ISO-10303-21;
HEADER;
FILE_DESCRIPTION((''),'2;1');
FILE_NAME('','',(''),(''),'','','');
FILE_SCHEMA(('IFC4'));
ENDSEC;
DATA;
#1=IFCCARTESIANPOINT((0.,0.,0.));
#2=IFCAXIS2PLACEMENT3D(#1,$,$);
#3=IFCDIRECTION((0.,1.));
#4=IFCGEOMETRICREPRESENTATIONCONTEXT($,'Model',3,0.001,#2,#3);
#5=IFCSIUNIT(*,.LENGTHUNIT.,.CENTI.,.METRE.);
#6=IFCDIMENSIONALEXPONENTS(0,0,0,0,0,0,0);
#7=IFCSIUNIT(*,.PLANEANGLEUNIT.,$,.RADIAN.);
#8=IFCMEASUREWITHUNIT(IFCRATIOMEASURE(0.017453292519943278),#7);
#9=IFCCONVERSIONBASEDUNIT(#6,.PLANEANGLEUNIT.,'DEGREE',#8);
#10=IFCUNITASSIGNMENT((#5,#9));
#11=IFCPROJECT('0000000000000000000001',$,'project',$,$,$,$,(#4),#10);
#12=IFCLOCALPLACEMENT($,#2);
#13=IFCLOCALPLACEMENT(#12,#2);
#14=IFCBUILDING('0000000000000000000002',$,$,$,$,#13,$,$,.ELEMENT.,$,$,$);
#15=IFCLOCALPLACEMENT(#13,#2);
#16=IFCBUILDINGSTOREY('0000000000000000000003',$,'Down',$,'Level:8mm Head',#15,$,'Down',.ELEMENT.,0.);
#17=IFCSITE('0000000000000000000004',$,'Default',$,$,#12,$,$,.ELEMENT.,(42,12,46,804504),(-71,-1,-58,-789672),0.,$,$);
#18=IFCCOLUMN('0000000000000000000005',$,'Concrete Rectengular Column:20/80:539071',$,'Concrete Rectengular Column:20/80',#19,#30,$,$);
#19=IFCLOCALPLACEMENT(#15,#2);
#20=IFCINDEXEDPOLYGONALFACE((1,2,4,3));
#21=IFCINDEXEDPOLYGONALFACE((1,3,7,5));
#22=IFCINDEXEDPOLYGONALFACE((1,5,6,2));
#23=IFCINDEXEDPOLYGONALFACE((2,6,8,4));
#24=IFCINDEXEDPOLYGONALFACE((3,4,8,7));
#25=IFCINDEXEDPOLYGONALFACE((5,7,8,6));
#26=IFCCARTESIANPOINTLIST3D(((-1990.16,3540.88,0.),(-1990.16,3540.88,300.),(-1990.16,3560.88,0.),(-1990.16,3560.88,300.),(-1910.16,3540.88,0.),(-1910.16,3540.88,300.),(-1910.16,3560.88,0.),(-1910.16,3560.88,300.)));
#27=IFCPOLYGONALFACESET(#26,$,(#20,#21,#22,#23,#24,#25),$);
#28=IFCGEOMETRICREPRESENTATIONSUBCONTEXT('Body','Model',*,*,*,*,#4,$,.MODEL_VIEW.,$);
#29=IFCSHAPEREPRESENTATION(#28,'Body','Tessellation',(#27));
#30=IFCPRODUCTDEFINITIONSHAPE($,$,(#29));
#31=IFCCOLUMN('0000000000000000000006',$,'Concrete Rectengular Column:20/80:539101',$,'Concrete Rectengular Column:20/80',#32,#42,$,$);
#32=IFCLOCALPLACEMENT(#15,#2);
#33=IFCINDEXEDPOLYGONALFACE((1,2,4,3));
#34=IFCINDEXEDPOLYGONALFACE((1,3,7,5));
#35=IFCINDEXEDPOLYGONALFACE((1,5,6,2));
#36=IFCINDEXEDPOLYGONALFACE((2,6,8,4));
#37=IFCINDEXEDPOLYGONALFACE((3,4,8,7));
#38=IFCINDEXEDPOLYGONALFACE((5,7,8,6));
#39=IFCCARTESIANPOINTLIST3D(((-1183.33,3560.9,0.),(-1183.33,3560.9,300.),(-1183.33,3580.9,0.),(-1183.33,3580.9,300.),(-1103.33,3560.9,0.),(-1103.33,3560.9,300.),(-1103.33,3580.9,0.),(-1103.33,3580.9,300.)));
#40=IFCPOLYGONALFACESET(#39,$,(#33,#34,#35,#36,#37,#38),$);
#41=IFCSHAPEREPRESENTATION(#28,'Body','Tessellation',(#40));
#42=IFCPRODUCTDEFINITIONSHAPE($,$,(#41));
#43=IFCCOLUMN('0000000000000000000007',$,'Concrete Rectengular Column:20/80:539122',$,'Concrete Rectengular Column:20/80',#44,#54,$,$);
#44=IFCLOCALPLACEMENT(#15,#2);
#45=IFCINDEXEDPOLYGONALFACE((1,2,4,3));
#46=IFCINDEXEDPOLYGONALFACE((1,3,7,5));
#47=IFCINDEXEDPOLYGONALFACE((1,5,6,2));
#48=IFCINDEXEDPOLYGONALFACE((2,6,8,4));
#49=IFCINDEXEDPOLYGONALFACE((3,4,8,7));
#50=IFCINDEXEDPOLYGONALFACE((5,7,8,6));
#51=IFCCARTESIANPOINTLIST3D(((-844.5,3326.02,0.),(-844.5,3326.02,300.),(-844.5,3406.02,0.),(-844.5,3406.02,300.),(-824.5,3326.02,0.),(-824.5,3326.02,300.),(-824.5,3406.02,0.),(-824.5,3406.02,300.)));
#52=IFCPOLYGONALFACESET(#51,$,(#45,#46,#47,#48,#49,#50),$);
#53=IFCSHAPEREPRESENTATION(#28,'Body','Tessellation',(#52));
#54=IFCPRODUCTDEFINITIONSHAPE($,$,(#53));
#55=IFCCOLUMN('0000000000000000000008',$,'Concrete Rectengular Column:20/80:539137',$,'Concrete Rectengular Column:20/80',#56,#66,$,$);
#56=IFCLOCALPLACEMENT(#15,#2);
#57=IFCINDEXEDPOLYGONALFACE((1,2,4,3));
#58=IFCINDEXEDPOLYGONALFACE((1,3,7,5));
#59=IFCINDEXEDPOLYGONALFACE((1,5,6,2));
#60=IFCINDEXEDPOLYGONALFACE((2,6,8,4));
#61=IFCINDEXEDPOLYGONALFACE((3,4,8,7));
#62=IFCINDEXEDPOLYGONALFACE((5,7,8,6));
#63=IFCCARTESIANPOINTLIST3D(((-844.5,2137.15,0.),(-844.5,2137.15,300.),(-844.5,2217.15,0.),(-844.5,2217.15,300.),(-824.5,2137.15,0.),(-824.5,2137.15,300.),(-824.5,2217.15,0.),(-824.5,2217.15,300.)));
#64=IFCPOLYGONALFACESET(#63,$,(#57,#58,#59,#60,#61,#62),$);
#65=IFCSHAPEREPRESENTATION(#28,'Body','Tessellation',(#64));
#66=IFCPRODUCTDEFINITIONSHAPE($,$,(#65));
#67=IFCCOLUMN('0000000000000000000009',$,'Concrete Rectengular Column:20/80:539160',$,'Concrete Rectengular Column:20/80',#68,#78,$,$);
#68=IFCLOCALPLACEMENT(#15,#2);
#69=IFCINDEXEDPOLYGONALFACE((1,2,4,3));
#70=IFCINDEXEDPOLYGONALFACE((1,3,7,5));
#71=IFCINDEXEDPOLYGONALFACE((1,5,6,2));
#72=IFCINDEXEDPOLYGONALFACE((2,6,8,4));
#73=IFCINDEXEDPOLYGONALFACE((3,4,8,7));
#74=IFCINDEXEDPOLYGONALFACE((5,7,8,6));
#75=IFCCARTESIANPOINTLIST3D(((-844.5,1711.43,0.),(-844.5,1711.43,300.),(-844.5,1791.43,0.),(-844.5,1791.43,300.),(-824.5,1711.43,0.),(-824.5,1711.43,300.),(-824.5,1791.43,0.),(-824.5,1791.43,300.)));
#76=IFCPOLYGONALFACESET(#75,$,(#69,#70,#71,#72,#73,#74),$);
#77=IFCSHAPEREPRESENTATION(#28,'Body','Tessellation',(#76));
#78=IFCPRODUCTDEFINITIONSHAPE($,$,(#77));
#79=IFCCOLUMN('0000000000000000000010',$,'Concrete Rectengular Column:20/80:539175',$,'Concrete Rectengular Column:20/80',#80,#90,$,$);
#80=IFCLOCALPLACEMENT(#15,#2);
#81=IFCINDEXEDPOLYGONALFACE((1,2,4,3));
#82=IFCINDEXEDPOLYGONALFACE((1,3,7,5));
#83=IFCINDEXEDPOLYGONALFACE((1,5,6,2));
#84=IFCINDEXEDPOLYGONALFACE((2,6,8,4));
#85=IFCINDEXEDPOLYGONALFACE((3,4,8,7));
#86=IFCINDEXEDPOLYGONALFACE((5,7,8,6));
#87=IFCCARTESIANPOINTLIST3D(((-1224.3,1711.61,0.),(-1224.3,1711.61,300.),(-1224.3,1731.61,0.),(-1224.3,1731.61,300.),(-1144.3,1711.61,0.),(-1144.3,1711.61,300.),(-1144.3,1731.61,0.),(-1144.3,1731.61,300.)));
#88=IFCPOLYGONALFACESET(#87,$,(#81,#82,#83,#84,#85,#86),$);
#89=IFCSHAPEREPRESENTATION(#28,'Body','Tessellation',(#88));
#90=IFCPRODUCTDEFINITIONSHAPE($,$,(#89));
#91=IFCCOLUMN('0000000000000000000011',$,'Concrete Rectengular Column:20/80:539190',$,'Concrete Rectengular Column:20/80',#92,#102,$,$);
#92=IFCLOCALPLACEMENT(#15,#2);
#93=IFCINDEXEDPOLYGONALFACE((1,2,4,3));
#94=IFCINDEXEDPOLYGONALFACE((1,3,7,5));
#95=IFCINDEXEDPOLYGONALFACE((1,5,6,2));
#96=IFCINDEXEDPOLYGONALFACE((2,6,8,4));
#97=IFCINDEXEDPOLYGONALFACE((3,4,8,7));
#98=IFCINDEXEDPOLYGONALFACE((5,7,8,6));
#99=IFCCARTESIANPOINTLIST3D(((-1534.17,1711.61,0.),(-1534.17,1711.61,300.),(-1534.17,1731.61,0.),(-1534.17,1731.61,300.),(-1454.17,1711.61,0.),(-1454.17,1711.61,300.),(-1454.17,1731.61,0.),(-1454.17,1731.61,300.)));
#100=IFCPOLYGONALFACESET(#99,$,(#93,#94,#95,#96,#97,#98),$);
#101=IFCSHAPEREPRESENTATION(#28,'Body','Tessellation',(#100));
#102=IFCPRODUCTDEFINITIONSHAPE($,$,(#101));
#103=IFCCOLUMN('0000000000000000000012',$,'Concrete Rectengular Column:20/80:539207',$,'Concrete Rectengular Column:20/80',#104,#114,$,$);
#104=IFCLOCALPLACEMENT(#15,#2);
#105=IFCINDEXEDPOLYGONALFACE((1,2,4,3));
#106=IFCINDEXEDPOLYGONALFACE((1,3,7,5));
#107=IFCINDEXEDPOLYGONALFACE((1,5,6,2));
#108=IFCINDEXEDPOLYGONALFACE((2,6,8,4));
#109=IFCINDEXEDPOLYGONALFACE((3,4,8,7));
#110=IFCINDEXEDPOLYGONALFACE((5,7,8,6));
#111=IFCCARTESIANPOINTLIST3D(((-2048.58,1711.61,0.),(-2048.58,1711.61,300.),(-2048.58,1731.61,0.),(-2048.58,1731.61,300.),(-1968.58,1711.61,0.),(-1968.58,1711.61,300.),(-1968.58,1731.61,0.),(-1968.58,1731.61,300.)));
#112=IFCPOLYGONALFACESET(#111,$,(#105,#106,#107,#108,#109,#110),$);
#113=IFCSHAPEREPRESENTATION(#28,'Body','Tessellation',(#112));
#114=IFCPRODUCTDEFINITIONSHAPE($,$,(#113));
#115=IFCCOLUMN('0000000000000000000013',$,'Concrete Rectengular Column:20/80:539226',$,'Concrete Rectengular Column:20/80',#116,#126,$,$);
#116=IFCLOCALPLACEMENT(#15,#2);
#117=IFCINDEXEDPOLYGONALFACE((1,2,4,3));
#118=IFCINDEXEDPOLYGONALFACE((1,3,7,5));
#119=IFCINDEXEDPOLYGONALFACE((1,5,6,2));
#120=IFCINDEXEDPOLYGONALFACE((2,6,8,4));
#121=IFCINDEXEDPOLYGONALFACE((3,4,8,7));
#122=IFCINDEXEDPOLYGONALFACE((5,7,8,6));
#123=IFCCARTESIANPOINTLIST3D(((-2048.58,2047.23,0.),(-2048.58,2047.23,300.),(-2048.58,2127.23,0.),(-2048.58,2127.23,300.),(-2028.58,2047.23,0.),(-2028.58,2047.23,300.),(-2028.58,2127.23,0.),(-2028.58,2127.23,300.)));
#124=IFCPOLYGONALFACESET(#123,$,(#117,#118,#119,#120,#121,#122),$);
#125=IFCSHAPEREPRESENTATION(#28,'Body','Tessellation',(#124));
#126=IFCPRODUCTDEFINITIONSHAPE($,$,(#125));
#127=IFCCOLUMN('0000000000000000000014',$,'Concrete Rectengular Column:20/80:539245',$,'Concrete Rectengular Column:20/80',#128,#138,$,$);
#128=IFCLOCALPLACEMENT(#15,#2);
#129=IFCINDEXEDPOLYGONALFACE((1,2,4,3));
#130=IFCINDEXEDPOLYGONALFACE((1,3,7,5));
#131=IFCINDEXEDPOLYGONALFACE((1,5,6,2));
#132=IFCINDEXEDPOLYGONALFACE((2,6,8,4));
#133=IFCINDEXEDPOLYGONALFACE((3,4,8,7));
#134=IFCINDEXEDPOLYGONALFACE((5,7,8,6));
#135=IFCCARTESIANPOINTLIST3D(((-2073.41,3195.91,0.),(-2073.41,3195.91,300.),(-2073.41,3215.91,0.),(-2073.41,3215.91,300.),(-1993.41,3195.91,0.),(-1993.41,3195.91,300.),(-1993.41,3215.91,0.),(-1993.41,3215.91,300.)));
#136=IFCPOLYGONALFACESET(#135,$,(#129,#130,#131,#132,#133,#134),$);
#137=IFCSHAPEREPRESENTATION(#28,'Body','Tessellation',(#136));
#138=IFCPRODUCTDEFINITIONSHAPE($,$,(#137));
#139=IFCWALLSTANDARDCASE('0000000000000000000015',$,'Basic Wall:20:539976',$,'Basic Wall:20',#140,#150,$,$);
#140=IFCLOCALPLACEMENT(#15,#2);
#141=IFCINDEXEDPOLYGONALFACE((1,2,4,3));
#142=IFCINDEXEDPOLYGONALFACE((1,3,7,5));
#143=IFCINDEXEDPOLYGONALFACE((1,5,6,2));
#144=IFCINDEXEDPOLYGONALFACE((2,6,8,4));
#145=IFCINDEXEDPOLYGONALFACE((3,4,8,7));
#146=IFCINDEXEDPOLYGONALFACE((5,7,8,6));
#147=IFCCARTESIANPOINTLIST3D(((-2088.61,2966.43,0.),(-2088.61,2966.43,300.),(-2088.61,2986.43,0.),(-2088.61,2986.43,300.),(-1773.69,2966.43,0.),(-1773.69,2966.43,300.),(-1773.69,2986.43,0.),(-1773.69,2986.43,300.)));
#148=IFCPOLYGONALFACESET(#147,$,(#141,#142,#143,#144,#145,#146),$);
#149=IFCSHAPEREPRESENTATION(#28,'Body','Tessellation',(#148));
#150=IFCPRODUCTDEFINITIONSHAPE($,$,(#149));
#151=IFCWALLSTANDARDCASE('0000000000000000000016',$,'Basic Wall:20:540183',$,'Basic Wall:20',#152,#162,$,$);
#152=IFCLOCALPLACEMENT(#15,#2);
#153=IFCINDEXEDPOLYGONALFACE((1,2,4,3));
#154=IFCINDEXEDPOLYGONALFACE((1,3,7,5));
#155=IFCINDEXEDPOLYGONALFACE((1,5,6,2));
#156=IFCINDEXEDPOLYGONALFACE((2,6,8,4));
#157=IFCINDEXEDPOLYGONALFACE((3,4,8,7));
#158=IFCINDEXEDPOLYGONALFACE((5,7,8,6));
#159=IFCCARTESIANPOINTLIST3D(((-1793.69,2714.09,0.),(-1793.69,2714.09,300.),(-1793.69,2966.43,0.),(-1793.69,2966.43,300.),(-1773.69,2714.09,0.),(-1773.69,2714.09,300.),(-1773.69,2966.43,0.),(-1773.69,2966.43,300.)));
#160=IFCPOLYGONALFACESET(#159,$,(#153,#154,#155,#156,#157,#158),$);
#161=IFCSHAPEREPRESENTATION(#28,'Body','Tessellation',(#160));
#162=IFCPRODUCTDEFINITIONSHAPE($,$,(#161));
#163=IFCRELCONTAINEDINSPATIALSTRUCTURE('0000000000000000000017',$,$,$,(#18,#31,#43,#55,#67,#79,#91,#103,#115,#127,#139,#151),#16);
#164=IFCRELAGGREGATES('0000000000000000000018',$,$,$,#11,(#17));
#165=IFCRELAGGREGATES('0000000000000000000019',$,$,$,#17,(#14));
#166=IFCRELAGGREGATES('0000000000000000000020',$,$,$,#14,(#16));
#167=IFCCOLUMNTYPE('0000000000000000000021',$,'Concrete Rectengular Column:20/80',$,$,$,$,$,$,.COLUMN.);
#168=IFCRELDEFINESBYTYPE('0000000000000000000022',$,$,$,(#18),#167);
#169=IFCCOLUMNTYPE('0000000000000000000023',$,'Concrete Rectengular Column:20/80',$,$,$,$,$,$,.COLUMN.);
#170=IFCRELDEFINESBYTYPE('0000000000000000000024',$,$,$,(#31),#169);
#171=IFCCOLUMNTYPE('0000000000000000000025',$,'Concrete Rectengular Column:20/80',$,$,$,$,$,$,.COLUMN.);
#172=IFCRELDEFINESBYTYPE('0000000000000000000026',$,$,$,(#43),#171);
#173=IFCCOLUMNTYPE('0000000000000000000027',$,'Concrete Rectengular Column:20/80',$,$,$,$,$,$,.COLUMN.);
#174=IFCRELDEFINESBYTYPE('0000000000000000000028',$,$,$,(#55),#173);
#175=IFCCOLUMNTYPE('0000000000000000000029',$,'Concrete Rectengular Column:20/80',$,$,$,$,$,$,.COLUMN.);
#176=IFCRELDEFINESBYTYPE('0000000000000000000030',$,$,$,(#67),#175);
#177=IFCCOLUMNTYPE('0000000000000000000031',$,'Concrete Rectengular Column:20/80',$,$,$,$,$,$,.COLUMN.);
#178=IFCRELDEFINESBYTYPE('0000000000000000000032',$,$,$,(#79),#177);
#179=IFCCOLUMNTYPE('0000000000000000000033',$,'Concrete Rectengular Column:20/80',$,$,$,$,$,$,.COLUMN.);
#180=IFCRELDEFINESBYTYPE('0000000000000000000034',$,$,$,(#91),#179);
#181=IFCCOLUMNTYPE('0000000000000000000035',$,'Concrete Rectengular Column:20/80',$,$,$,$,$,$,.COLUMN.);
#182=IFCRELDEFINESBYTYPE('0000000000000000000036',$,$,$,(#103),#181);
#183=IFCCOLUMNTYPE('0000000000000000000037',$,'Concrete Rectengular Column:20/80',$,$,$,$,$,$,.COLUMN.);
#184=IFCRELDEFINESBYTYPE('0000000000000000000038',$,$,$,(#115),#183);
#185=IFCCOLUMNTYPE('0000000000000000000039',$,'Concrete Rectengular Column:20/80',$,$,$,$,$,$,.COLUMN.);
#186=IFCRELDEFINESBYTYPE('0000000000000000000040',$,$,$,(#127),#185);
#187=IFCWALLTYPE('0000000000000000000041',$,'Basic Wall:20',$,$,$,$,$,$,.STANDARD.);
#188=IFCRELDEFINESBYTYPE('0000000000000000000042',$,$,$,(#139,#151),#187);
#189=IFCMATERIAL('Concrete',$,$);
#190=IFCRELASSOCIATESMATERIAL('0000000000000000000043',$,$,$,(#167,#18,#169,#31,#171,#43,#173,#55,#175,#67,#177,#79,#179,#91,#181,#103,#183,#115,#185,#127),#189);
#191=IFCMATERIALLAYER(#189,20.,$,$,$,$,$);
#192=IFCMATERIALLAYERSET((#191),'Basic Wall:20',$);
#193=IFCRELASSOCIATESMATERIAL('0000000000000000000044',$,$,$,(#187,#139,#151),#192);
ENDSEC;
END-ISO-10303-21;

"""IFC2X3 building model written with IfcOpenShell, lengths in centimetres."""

from ifc_helpers import new_model, entity, si_unit, converted_unit, direction, frame, frame_2d, origin, origin_2d_with_axis, place, context, subcontext, project, spatial, rectangle, extrude, source, transform, mapped, material, layer, layer_set, layer_usage, type_object, type_shapes, element, save


model = new_model("IFC2X3")

# Units and contexts
model_context = context("Model", 3, precision=0.001, world=origin(), true_north=direction((0.0, 1.0)))
body_context = subcontext(model_context, "Body", "Model", "MODEL_VIEW")
ifc_project = project(units=[si_unit("LENGTHUNIT", "METRE", prefix="CENTI"), converted_unit("PLANEANGLEUNIT", "DEGREE", entity("IfcRatioMeasure", 0.017453292519943278), si_unit("PLANEANGLEUNIT", "RADIAN"), dimensions=[0, 0, 0, 0, 0, 0, 0])], contexts=[model_context])

# Site, building, storey
site_placement = place(None, origin())
site = spatial("IfcSite", under=ifc_project, at=site_placement, Name="Default", CompositionType="ELEMENT", RefLatitude=(42, 12, 46, 804504), RefLongitude=(-71, -1, -58, -789672), RefElevation=0.0)
building_placement = place(site_placement, origin())
building = spatial("IfcBuilding", under=site, at=building_placement, CompositionType="ELEMENT")
storey_placement = place(building_placement, origin())
storey = spatial("IfcBuildingStorey", under=building, at=storey_placement, Name="Down", ObjectType="Level:8mm Head", LongName="Down", CompositionType="ELEMENT", Elevation=0.0)

# Columns
ifc_material = material(Name="Concrete")
column_type_1 = type_object("IfcColumnType", Name="Concrete Rectengular Column:20/80", PredefinedType="COLUMN", material=ifc_material)
shared_shape_1 = source(origin(), body_context, "Body", "SweptSolid", [
    extrude(rectangle(XDim=20.0, YDim=80.0, at=origin_2d_with_axis()), frame((-1950.16, 3550.88, 0.0), z_axis=(0.0, 0.0, 1.0), x_axis=(0.0, -1.0, 0.0)), (0.0, 0.0, 1.0), 300.0),
])
type_shapes(column_type_1, [shared_shape_1])
column_1_placement = place(storey_placement, origin())
element("IfcColumn", 1, at=column_1_placement, inside=storey, type_object=column_type_1, material=ifc_material, Name="Concrete Rectengular Column:20/80:539071", ObjectType="Concrete Rectengular Column:20/80", context=body_context, shape_type="MappedRepresentation", body=[
    mapped(shared_shape_1, transform((0.0, 0.0, 0.0), scale=1.0)),
])
column_type_2 = type_object("IfcColumnType", Name="Concrete Rectengular Column:20/80", PredefinedType="COLUMN", material=ifc_material)
shared_shape_2 = source(origin(), body_context, "Body", "SweptSolid", [
    extrude(rectangle(XDim=20.0, YDim=80.0, at=origin_2d_with_axis()), frame((-1143.33, 3570.9, 0.0), z_axis=(0.0, 0.0, 1.0), x_axis=(0.0, -1.0, 0.0)), (0.0, 0.0, 1.0), 300.0),
])
type_shapes(column_type_2, [shared_shape_2])
column_2_placement = place(storey_placement, origin())
element("IfcColumn", 2, at=column_2_placement, inside=storey, type_object=column_type_2, material=ifc_material, Name="Concrete Rectengular Column:20/80:539101", ObjectType="Concrete Rectengular Column:20/80", context=body_context, shape_type="MappedRepresentation", body=[
    mapped(shared_shape_2, transform((0.0, 0.0, 0.0), scale=1.0)),
])
column_type_3 = type_object("IfcColumnType", Name="Concrete Rectengular Column:20/80", PredefinedType="COLUMN", material=ifc_material)
shared_shape_3 = source(origin(), body_context, "Body", "SweptSolid", [
    extrude(rectangle(XDim=80.0, YDim=20.0, at=origin_2d_with_axis()), frame((-834.5, 3366.02, 0.0), z_axis=(0.0, 0.0, 1.0), x_axis=(0.0, -1.0, 0.0)), (0.0, 0.0, 1.0), 300.0),
])
type_shapes(column_type_3, [shared_shape_3])
column_3_placement = place(storey_placement, origin())
element("IfcColumn", 3, at=column_3_placement, inside=storey, type_object=column_type_3, material=ifc_material, Name="Concrete Rectengular Column:20/80:539122", ObjectType="Concrete Rectengular Column:20/80", context=body_context, shape_type="MappedRepresentation", body=[
    mapped(shared_shape_3, transform((0.0, 0.0, 0.0), scale=1.0)),
])
column_type_4 = type_object("IfcColumnType", Name="Concrete Rectengular Column:20/80", PredefinedType="COLUMN", material=ifc_material)
shared_shape_4 = source(origin(), body_context, "Body", "SweptSolid", [
    extrude(rectangle(XDim=80.0, YDim=20.0, at=origin_2d_with_axis()), frame((-834.5, 2177.15, 0.0), z_axis=(0.0, 0.0, 1.0), x_axis=(0.0, -1.0, 0.0)), (0.0, 0.0, 1.0), 300.0),
])
type_shapes(column_type_4, [shared_shape_4])
column_4_placement = place(storey_placement, origin())
element("IfcColumn", 4, at=column_4_placement, inside=storey, type_object=column_type_4, material=ifc_material, Name="Concrete Rectengular Column:20/80:539137", ObjectType="Concrete Rectengular Column:20/80", context=body_context, shape_type="MappedRepresentation", body=[
    mapped(shared_shape_4, transform((0.0, 0.0, 0.0), scale=1.0)),
])
column_type_5 = type_object("IfcColumnType", Name="Concrete Rectengular Column:20/80", PredefinedType="COLUMN", material=ifc_material)
shared_shape_5 = source(origin(), body_context, "Body", "SweptSolid", [
    extrude(rectangle(XDim=80.0, YDim=20.0, at=origin_2d_with_axis()), frame((-834.5, 1751.43, 0.0), z_axis=(0.0, 0.0, 1.0), x_axis=(0.0, -1.0, 0.0)), (0.0, 0.0, 1.0), 300.0),
])
type_shapes(column_type_5, [shared_shape_5])
column_5_placement = place(storey_placement, origin())
element("IfcColumn", 5, at=column_5_placement, inside=storey, type_object=column_type_5, material=ifc_material, Name="Concrete Rectengular Column:20/80:539160", ObjectType="Concrete Rectengular Column:20/80", context=body_context, shape_type="MappedRepresentation", body=[
    mapped(shared_shape_5, transform((0.0, 0.0, 0.0), scale=1.0)),
])
column_type_6 = type_object("IfcColumnType", Name="Concrete Rectengular Column:20/80", PredefinedType="COLUMN", material=ifc_material)
shared_shape_6 = source(origin(), body_context, "Body", "SweptSolid", [
    extrude(rectangle(XDim=20.0, YDim=80.0, at=frame_2d((0.0, 0.0), x_axis=(1.0, 0.0))), frame((-1184.3, 1721.61, 0.0), z_axis=(0.0, 0.0, 1.0), x_axis=(0.0, -1.0, 0.0)), (0.0, 0.0, 1.0), 300.0),
])
type_shapes(column_type_6, [shared_shape_6])
column_6_placement = place(storey_placement, origin())
element("IfcColumn", 6, at=column_6_placement, inside=storey, type_object=column_type_6, material=ifc_material, Name="Concrete Rectengular Column:20/80:539175", ObjectType="Concrete Rectengular Column:20/80", context=body_context, shape_type="MappedRepresentation", body=[
    mapped(shared_shape_6, transform((0.0, 0.0, 0.0), scale=1.0)),
])
column_type_7 = type_object("IfcColumnType", Name="Concrete Rectengular Column:20/80", PredefinedType="COLUMN", material=ifc_material)
shared_shape_7 = source(origin(), body_context, "Body", "SweptSolid", [
    extrude(rectangle(XDim=20.0, YDim=80.0, at=frame_2d((0.0, 0.0), x_axis=(1.0, 0.0))), frame((-1494.17, 1721.61, 0.0), z_axis=(0.0, 0.0, 1.0), x_axis=(0.0, -1.0, 0.0)), (0.0, 0.0, 1.0), 300.0),
])
type_shapes(column_type_7, [shared_shape_7])
column_7_placement = place(storey_placement, origin())
element("IfcColumn", 7, at=column_7_placement, inside=storey, type_object=column_type_7, material=ifc_material, Name="Concrete Rectengular Column:20/80:539190", ObjectType="Concrete Rectengular Column:20/80", context=body_context, shape_type="MappedRepresentation", body=[
    mapped(shared_shape_7, transform((0.0, 0.0, 0.0), scale=1.0)),
])
column_type_8 = type_object("IfcColumnType", Name="Concrete Rectengular Column:20/80", PredefinedType="COLUMN", material=ifc_material)
shared_shape_8 = source(origin(), body_context, "Body", "SweptSolid", [
    extrude(rectangle(XDim=20.0, YDim=80.0, at=frame_2d((0.0, 0.0), x_axis=(1.0, 0.0))), frame((-2008.58, 1721.61, 0.0), z_axis=(0.0, 0.0, 1.0), x_axis=(0.0, -1.0, 0.0)), (0.0, 0.0, 1.0), 300.0),
])
type_shapes(column_type_8, [shared_shape_8])
column_8_placement = place(storey_placement, origin())
element("IfcColumn", 8, at=column_8_placement, inside=storey, type_object=column_type_8, material=ifc_material, Name="Concrete Rectengular Column:20/80:539207", ObjectType="Concrete Rectengular Column:20/80", context=body_context, shape_type="MappedRepresentation", body=[
    mapped(shared_shape_8, transform((0.0, 0.0, 0.0), scale=1.0)),
])
column_type_9 = type_object("IfcColumnType", Name="Concrete Rectengular Column:20/80", PredefinedType="COLUMN", material=ifc_material)
shared_shape_9 = source(origin(), body_context, "Body", "SweptSolid", [
    extrude(rectangle(XDim=80.0, YDim=20.0, at=origin_2d_with_axis()), frame((-2038.58, 2087.23, 0.0), z_axis=(0.0, 0.0, 1.0), x_axis=(0.0, -1.0, 0.0)), (0.0, 0.0, 1.0), 300.0),
])
type_shapes(column_type_9, [shared_shape_9])
column_9_placement = place(storey_placement, origin())
element("IfcColumn", 9, at=column_9_placement, inside=storey, type_object=column_type_9, material=ifc_material, Name="Concrete Rectengular Column:20/80:539226", ObjectType="Concrete Rectengular Column:20/80", context=body_context, shape_type="MappedRepresentation", body=[
    mapped(shared_shape_9, transform((0.0, 0.0, 0.0), scale=1.0)),
])
column_type_10 = type_object("IfcColumnType", Name="Concrete Rectengular Column:20/80", PredefinedType="COLUMN", material=ifc_material)
shared_shape_10 = source(origin(), body_context, "Body", "SweptSolid", [
    extrude(rectangle(XDim=20.0, YDim=80.0, at=origin_2d_with_axis()), frame((-2033.41, 3205.91, 0.0), z_axis=(0.0, 0.0, 1.0), x_axis=(0.0, -1.0, 0.0)), (0.0, 0.0, 1.0), 300.0),
])
type_shapes(column_type_10, [shared_shape_10])
column_10_placement = place(storey_placement, origin())
element("IfcColumn", 10, at=column_10_placement, inside=storey, type_object=column_type_10, material=ifc_material, Name="Concrete Rectengular Column:20/80:539245", ObjectType="Concrete Rectengular Column:20/80", context=body_context, shape_type="MappedRepresentation", body=[
    mapped(shared_shape_10, transform((0.0, 0.0, 0.0), scale=1.0)),
])

# Walls
ifc_layer_1 = layer(ifc_material, 20.0)
ifc_layer_set_1 = layer_set([ifc_layer_1], Name="Basic Wall:20")
ifc_layer_usage_1 = layer_usage(ifc_layer_set_1, "AXIS2", "NEGATIVE", 10.0)
wall_type_1 = type_object("IfcWallType", Name="Basic Wall:20", PredefinedType="STANDARD", material=ifc_layer_set_1)
wall_1_placement = place(storey_placement, frame((-2088.61, 2976.43, 0.0)))
element("IfcWallStandardCase", 11, at=wall_1_placement, inside=storey, type_object=wall_type_1, material=ifc_layer_usage_1, Name="Basic Wall:20:539976", ObjectType="Basic Wall:20", context=body_context, shape_type="SweptSolid", body=[
    extrude(rectangle(XDim=314.92, YDim=20.0, at=frame_2d((157.46, 0.0), x_axis=(-1.0, 0.0))), origin(), (0.0, 0.0, 1.0), 300.0),
])
ifc_layer_usage_2 = layer_usage(ifc_layer_set_1, "AXIS2", "NEGATIVE", 10.0)
wall_2_placement = place(storey_placement, frame((-1783.69, 2966.43, 0.0), z_axis=(0.0, 0.0, 1.0), x_axis=(0.0, -1.0, 0.0)))
element("IfcWallStandardCase", 12, at=wall_2_placement, inside=storey, type_object=wall_type_1, material=ifc_layer_usage_2, Name="Basic Wall:20:540183", ObjectType="Basic Wall:20", context=body_context, shape_type="SweptSolid", body=[
    extrude(rectangle(XDim=252.33, YDim=20.0, at=frame_2d((126.17, 0.0), x_axis=(-1.0, 0.0))), origin(), (0.0, 0.0, 1.0), 300.0),
])

save(model, "model.ifc")
